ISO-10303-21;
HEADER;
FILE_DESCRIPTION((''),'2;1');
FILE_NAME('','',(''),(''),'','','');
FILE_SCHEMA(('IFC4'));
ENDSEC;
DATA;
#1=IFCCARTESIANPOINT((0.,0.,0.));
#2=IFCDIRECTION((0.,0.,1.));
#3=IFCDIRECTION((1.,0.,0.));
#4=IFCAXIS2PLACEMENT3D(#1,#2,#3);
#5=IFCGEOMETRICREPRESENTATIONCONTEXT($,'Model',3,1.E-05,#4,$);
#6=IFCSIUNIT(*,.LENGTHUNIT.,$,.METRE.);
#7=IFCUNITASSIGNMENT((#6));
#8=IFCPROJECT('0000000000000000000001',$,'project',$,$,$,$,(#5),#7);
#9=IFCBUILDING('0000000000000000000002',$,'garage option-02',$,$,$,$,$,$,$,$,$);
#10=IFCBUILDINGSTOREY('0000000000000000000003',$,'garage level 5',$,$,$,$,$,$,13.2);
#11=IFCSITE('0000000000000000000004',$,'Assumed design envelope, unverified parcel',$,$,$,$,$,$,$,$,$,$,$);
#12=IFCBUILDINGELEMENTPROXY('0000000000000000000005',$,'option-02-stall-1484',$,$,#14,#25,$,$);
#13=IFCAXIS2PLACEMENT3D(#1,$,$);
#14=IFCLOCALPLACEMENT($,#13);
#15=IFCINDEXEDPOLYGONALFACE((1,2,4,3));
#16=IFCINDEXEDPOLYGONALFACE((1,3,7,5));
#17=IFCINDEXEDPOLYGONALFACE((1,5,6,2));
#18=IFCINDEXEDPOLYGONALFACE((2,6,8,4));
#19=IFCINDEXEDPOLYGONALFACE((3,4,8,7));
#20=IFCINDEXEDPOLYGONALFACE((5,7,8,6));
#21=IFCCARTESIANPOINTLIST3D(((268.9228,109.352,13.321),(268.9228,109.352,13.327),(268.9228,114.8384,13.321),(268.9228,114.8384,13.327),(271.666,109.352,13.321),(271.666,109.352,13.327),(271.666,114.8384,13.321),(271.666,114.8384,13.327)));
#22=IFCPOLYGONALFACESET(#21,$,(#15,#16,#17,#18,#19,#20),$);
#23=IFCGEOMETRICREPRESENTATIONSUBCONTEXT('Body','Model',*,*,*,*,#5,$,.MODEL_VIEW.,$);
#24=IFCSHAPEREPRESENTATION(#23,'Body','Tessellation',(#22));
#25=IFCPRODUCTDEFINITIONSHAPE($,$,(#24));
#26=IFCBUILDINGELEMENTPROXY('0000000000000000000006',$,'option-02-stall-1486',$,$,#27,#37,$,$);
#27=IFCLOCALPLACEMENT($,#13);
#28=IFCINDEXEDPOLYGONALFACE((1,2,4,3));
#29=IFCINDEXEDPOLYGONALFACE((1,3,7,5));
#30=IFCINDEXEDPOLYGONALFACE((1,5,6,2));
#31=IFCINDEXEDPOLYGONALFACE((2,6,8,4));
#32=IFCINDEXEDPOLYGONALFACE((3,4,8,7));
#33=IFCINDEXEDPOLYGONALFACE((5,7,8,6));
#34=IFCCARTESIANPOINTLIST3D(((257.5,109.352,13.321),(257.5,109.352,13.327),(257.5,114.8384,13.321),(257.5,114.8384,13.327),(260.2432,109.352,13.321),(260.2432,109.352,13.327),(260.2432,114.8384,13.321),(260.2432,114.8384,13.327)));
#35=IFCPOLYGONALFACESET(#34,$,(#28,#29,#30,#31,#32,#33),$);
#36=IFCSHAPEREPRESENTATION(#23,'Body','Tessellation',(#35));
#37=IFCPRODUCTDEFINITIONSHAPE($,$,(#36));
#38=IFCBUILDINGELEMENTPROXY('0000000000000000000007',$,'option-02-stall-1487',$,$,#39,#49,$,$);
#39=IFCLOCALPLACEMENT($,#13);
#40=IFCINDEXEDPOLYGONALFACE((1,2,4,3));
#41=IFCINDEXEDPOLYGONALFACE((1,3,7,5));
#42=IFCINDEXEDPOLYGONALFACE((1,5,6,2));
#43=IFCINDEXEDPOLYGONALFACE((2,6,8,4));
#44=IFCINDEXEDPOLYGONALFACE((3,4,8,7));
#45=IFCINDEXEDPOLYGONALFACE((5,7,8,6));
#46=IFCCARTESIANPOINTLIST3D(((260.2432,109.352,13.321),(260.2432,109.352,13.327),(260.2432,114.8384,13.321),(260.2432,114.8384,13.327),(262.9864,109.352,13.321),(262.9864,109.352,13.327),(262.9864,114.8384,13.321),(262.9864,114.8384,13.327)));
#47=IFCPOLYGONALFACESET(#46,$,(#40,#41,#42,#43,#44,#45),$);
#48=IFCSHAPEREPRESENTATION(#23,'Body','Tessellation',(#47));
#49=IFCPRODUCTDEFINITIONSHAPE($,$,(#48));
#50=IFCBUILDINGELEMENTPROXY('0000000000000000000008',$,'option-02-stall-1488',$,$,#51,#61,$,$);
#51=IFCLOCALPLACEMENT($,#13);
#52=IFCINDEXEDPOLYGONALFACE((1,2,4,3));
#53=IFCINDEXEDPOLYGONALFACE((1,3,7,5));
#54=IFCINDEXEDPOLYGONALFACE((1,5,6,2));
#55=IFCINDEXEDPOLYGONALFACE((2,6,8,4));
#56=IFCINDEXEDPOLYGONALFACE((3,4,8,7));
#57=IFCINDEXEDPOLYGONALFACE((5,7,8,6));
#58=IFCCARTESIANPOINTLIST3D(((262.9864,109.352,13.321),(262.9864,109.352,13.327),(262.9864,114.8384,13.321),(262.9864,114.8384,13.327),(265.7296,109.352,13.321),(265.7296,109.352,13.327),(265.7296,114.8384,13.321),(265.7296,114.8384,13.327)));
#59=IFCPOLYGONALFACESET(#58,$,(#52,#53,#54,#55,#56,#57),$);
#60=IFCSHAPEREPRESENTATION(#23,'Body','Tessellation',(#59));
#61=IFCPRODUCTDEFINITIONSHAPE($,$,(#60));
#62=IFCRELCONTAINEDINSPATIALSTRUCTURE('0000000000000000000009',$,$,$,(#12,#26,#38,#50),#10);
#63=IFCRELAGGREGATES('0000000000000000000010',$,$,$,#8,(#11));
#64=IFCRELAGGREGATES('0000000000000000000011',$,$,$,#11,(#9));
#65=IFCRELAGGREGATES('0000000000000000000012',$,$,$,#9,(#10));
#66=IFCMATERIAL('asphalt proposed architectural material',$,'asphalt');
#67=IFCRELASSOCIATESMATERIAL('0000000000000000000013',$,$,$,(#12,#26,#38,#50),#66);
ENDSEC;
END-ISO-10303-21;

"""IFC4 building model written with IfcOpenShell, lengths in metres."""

from ifc_helpers import new_model, si_unit, frame, origin_with_axes, place, context, subcontext, project, spatial, rectangle, extrude, material, element, save


model = new_model("IFC4")

# Units and contexts
model_context = context("Model", 3, precision=1e-05, world=origin_with_axes())
body_context = subcontext(model_context, "Body", "Model", "MODEL_VIEW")
ifc_project = project(units=[si_unit("LENGTHUNIT", "METRE")], contexts=[model_context])

# Site, building, storey
site = spatial("IfcSite", under=ifc_project, Name="Assumed design envelope, unverified parcel")
building = spatial("IfcBuilding", under=site, Name="garage option-02")
storey = spatial("IfcBuildingStorey", under=building, Name="garage level 5", Elevation=13.2)

# Building element proxies
ifc_material_1 = material(Name="asphalt proposed architectural material", Category="asphalt")
for number, where, z_axis, x_axis, name in (
    (1, (270.2944, 112.0952, 13.321), (0.0, 0.0, 1.0), (1.0, 0.0, 0.0), "option-02-stall-1484"),
    (2, (258.8716, 112.0952, 13.321), (0.0, 0.0, 1.0), (1.0, 0.0, 0.0), "option-02-stall-1486"),
    (3, (261.6148, 112.0952, 13.321), (0.0, 0.0, 1.0), (1.0, 0.0, 0.0), "option-02-stall-1487"),
    (4, (264.358, 112.0952, 13.321), (0.0, 0.0, 1.0), (1.0, 0.0, 0.0), "option-02-stall-1488"),
):
    element("IfcBuildingElementProxy", number, at=place(None, frame(where, z_axis=z_axis, x_axis=x_axis)), inside=storey, material=ifc_material_1, Name=name, context=body_context, shape_type="SweptSolid", body=[
        extrude(rectangle(XDim=2.7432, YDim=5.4864), origin_with_axes(), (0.0, 0.0, 1.0), 0.006),
    ])

save(model, "model.ifc")
